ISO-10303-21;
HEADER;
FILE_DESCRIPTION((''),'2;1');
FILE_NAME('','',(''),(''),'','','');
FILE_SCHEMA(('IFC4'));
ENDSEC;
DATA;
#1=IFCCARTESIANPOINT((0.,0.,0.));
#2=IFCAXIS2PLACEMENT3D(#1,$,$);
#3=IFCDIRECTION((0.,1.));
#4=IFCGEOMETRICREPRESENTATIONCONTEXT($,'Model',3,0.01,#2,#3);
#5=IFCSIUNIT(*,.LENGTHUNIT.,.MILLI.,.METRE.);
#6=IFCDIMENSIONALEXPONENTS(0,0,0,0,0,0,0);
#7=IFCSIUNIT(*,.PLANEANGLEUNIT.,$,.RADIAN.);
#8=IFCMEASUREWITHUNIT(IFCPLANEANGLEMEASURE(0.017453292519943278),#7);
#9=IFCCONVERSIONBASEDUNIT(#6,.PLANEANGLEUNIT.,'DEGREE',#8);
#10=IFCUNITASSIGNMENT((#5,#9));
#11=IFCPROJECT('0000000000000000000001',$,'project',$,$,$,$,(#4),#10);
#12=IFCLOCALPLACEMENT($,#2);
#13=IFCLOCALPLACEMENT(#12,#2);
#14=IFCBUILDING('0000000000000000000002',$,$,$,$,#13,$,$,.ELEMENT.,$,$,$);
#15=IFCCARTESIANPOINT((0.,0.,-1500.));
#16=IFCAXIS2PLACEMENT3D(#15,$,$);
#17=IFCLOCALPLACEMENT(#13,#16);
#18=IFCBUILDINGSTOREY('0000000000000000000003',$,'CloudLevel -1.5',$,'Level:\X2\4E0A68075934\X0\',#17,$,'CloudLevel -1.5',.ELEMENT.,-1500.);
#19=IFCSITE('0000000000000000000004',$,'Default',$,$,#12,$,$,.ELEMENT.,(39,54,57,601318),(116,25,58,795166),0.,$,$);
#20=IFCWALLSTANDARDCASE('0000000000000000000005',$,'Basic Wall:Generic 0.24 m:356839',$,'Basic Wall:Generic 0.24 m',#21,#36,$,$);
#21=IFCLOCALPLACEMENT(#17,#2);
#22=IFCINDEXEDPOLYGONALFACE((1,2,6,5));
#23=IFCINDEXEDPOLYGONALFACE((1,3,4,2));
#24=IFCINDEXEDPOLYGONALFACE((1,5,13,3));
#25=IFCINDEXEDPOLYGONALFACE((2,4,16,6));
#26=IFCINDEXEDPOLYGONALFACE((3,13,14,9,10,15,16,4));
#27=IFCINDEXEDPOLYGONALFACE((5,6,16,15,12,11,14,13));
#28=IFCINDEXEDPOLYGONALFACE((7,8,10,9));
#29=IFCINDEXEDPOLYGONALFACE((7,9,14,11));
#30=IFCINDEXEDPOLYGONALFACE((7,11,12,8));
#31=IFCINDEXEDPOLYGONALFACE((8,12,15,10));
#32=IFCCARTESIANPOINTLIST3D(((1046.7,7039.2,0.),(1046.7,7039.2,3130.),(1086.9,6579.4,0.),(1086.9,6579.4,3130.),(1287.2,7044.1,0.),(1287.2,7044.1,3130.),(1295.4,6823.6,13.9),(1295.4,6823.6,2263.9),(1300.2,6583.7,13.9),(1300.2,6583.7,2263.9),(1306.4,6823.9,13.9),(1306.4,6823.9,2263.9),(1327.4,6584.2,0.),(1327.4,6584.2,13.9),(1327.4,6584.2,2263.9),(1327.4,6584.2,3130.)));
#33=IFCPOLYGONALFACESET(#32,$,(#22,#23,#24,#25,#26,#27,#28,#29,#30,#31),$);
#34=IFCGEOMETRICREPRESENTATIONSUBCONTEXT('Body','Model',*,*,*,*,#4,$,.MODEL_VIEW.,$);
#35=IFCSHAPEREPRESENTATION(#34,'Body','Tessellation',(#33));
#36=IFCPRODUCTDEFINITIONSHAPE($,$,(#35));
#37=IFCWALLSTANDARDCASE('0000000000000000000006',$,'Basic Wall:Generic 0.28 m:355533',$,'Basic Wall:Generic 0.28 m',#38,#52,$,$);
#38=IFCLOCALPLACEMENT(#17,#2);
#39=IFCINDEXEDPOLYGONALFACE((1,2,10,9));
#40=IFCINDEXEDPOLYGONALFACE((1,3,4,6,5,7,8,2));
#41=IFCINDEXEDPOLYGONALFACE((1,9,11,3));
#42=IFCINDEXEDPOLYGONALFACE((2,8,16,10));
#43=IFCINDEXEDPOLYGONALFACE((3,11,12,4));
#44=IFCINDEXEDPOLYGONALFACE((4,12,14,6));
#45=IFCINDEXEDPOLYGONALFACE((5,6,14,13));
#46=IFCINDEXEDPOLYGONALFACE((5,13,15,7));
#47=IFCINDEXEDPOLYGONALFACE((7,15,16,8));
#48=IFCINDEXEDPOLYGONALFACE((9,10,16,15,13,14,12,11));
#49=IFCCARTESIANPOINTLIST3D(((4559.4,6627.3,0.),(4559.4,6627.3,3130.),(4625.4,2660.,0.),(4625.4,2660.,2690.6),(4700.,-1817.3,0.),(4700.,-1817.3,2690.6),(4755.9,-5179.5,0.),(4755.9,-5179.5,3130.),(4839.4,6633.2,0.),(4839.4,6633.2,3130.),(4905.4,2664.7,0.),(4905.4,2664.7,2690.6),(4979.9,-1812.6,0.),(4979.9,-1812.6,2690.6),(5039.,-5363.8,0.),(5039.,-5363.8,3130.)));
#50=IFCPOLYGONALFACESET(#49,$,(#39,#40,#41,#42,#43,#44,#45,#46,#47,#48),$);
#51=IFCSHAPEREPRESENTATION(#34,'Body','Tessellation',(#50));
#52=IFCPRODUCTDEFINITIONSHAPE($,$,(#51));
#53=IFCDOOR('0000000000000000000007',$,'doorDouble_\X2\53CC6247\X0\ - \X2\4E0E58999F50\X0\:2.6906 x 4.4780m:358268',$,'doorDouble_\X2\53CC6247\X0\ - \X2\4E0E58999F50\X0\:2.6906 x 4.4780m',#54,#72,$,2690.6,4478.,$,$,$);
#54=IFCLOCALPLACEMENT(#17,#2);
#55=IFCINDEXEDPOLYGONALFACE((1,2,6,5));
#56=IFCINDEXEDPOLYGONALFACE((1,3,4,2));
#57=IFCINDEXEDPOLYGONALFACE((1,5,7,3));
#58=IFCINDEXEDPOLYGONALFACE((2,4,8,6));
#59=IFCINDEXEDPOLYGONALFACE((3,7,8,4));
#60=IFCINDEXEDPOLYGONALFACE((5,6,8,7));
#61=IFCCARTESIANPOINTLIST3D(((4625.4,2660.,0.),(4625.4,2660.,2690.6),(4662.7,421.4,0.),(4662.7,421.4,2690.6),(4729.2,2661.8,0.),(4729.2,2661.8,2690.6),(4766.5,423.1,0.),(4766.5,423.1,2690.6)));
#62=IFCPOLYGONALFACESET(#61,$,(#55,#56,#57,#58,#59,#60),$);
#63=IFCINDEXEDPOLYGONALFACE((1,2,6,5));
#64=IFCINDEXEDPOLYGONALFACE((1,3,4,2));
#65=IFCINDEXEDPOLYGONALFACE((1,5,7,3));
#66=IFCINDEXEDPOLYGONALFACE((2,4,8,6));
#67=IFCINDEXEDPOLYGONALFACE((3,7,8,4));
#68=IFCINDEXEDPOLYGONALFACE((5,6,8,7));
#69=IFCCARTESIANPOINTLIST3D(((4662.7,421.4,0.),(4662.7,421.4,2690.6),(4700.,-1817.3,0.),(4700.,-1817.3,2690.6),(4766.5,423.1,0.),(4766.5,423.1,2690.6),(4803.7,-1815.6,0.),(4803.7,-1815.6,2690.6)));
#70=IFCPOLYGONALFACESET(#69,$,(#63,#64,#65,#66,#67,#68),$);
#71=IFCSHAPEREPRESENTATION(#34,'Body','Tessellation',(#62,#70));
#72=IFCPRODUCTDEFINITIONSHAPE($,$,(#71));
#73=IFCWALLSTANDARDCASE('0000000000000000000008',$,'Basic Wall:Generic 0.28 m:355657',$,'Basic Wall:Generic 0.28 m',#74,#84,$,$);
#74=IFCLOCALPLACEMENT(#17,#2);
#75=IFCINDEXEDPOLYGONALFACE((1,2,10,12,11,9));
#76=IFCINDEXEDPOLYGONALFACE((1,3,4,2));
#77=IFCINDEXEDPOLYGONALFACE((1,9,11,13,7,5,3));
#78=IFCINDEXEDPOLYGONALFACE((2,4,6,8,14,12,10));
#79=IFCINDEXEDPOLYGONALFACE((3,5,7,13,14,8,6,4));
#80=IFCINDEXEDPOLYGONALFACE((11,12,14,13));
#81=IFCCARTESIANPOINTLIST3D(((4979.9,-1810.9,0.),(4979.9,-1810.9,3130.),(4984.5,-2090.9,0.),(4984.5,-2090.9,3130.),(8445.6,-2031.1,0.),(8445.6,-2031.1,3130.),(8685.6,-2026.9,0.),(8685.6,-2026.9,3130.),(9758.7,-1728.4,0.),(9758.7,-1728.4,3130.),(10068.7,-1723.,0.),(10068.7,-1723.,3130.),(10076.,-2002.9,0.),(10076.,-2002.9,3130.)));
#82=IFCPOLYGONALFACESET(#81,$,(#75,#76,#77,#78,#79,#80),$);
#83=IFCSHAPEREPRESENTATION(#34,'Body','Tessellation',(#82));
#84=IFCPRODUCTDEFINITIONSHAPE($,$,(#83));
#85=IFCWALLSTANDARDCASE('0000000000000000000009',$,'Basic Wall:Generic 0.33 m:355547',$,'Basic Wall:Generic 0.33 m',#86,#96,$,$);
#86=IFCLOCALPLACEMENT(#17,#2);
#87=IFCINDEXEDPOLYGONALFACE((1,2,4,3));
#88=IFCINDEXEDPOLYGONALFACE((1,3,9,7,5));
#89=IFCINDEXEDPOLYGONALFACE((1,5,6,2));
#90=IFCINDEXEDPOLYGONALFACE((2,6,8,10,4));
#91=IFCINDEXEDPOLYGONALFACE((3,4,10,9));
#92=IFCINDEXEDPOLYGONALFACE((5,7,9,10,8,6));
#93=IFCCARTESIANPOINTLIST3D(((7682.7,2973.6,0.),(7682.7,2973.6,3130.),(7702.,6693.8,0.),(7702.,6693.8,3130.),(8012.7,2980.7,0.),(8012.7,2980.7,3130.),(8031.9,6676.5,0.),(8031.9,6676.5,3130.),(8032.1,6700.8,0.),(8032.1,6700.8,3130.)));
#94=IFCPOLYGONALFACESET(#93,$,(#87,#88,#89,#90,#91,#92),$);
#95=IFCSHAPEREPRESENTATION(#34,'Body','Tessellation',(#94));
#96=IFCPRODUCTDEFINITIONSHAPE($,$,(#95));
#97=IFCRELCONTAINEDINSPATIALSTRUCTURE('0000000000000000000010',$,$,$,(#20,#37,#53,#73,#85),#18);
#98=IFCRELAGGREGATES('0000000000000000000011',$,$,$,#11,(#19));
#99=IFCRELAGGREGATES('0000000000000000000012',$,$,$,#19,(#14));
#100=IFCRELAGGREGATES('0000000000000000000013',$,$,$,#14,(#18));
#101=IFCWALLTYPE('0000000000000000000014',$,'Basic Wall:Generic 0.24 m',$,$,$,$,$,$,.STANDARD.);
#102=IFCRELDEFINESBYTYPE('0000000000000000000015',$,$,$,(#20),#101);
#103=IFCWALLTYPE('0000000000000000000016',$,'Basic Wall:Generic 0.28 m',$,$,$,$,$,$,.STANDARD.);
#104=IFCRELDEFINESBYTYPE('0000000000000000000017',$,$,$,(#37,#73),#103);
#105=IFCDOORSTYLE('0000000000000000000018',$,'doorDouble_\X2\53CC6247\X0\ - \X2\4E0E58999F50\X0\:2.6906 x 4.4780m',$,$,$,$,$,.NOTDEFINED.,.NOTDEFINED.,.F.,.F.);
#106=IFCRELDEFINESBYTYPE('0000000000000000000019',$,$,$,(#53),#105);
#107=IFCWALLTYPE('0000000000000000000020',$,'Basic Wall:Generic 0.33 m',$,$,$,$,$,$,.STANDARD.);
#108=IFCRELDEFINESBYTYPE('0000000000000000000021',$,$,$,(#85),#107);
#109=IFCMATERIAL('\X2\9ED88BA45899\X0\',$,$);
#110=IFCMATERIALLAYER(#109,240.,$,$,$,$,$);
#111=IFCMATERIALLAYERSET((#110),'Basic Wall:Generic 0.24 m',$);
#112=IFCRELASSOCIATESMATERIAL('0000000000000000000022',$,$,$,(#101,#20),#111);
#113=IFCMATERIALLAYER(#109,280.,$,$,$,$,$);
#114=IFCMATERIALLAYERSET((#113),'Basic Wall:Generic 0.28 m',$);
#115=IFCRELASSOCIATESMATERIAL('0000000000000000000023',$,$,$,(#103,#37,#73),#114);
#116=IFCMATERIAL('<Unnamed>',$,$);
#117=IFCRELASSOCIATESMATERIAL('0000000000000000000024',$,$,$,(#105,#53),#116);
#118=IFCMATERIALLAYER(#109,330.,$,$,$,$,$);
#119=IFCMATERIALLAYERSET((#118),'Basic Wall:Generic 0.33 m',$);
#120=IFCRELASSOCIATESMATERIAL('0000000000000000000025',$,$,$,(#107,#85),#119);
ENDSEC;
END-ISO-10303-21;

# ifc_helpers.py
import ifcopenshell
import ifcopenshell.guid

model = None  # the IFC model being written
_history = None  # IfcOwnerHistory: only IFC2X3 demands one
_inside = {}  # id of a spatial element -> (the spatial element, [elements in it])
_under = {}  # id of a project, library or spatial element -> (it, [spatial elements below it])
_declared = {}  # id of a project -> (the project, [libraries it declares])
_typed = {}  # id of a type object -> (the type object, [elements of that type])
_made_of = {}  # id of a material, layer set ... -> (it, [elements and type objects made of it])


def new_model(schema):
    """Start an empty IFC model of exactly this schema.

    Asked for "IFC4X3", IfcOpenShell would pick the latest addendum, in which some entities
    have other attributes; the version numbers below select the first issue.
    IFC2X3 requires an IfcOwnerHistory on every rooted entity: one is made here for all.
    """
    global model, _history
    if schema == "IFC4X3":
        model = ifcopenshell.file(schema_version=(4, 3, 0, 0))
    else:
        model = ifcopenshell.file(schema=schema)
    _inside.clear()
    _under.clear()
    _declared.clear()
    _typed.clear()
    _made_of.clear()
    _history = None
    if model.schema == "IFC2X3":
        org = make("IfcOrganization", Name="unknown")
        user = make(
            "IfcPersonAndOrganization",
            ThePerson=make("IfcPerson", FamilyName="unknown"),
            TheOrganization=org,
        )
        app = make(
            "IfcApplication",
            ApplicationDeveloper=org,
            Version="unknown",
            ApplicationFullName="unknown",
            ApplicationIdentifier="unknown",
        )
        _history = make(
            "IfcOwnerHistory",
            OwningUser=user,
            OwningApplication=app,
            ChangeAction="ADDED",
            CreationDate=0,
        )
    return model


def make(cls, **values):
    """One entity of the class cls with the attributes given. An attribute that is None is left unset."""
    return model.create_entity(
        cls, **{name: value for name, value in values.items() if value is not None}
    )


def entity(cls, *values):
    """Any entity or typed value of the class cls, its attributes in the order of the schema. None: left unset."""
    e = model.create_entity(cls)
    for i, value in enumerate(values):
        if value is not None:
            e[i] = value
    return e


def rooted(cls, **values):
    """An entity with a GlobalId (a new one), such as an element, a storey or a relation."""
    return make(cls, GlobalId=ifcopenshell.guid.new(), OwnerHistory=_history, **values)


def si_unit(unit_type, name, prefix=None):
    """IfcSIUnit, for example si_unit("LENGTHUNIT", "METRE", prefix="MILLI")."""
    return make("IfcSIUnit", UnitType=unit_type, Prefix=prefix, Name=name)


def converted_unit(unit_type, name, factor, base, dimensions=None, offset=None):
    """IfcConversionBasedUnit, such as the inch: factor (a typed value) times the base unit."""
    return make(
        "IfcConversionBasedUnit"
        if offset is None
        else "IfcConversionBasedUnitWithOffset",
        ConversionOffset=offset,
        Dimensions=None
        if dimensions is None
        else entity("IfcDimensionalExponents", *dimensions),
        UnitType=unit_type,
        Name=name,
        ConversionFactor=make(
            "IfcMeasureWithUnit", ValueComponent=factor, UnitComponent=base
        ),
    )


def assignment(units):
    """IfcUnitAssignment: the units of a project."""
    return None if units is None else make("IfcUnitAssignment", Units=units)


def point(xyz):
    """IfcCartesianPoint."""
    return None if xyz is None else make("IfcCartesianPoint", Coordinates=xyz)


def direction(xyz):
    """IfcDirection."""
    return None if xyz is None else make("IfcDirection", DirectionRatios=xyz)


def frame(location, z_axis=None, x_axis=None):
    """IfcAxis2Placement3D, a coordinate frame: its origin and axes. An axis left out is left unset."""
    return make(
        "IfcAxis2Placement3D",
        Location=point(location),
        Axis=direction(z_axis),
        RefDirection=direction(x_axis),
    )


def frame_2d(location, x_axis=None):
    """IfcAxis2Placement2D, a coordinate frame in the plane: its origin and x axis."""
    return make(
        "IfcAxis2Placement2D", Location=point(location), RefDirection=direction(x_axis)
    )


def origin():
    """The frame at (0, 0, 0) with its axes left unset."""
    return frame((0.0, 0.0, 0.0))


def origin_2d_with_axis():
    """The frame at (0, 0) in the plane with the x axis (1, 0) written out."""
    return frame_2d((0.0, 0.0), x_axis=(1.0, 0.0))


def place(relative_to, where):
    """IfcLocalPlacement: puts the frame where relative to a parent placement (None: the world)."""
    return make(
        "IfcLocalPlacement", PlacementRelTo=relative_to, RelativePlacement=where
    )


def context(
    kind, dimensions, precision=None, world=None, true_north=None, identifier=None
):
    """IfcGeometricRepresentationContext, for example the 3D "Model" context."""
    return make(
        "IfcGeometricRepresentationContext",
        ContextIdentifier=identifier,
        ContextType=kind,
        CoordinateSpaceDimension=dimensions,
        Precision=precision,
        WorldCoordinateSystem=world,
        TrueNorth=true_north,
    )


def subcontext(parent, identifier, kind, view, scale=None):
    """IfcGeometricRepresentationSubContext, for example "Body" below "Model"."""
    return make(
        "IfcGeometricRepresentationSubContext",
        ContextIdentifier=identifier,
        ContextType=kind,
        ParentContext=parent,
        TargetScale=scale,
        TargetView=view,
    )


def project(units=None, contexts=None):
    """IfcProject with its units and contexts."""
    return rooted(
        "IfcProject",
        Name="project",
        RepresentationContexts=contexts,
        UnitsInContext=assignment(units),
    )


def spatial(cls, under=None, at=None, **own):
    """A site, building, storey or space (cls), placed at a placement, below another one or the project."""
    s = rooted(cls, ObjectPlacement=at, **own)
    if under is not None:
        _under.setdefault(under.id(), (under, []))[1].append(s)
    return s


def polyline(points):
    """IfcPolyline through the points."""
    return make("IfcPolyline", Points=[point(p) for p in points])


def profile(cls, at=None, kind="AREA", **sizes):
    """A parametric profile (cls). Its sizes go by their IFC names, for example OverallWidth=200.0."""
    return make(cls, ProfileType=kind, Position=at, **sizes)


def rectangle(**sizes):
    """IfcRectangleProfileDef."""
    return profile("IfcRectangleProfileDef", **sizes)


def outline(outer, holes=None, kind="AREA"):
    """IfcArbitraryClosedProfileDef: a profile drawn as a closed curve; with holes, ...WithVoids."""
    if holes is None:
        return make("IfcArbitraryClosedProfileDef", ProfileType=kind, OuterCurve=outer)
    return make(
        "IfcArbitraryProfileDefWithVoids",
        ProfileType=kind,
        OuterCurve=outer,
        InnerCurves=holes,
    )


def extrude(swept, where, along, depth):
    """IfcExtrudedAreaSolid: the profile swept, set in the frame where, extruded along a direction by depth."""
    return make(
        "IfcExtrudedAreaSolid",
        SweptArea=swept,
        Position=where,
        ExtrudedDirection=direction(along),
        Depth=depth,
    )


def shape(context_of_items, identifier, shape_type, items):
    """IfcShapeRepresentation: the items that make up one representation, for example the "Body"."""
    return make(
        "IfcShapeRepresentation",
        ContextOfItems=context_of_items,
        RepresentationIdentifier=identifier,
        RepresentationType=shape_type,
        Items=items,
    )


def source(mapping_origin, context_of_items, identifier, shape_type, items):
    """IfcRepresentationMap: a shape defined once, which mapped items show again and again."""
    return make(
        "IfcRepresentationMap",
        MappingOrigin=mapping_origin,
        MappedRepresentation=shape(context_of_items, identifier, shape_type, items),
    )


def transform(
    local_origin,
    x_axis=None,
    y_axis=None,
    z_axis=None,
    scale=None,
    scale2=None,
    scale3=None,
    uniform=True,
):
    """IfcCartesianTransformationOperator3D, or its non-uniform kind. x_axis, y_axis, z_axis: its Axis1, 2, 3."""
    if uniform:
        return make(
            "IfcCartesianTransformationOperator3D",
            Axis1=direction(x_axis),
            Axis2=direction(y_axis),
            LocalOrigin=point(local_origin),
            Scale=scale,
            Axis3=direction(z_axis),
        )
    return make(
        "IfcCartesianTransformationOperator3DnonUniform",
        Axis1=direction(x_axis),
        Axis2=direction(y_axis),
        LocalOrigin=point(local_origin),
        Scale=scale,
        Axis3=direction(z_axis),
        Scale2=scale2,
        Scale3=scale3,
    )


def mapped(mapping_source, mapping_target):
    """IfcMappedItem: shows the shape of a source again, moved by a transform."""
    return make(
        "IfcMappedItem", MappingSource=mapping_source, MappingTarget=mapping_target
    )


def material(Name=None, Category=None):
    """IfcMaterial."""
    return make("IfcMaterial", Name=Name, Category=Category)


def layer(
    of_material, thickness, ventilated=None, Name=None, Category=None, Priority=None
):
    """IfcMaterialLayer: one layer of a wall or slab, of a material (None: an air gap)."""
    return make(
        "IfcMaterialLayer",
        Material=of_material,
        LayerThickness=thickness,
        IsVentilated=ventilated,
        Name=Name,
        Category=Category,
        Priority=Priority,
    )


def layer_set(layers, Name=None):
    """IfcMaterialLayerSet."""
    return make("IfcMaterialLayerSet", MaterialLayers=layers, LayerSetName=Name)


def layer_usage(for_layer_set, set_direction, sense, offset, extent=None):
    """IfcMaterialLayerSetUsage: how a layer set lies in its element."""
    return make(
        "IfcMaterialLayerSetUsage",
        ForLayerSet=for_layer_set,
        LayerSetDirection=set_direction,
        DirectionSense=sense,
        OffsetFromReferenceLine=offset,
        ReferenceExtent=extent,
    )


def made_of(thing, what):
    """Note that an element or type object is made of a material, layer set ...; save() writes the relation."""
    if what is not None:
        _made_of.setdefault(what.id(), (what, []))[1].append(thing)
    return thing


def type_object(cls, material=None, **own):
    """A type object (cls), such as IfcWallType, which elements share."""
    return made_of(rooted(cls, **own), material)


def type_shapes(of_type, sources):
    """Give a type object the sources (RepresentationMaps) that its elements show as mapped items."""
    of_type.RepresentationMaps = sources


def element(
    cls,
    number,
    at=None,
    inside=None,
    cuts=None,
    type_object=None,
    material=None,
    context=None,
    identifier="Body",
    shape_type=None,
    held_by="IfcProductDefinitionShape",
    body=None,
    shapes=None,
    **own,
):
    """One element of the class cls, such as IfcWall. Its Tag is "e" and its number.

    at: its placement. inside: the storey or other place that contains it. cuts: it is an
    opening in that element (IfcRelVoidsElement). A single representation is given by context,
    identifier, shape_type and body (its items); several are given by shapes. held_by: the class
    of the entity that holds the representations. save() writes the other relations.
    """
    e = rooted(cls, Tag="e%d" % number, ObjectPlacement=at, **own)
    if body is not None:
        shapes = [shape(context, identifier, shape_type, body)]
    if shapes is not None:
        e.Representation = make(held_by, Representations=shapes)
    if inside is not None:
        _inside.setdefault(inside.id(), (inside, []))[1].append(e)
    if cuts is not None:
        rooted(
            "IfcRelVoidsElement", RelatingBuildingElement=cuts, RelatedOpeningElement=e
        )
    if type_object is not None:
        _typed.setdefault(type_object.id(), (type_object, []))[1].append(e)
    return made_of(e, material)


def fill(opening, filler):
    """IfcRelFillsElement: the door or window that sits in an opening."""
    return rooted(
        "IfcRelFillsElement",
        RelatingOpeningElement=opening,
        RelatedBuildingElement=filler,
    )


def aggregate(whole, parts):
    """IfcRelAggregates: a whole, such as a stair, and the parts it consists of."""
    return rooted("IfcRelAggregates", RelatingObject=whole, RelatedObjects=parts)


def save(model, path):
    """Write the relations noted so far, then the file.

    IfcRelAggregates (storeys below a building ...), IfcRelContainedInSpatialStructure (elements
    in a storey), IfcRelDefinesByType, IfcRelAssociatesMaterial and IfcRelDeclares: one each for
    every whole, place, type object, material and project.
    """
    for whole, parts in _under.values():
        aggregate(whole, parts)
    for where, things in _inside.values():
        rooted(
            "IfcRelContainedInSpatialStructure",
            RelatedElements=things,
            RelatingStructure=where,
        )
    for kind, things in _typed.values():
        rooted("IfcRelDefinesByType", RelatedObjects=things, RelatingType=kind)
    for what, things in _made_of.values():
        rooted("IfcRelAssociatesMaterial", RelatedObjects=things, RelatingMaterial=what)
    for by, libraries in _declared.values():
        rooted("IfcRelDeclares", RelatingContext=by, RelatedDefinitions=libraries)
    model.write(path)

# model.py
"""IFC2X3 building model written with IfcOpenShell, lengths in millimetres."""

from ifc_helpers import new_model, entity, si_unit, converted_unit, direction, frame, frame_2d, origin, origin_2d_with_axis, place, context, subcontext, project, spatial, polyline, rectangle, outline, extrude, source, transform, mapped, material, layer, layer_set, layer_usage, type_object, type_shapes, element, fill, save


model = new_model("IFC2X3")

# Units and contexts
model_context = context("Model", 3, precision=0.01, world=origin(), true_north=direction((0.0, 1.0)))
body_context = subcontext(model_context, "Body", "Model", "MODEL_VIEW")
ifc_project = project(units=[si_unit("LENGTHUNIT", "METRE", prefix="MILLI"), converted_unit("PLANEANGLEUNIT", "DEGREE", entity("IfcPlaneAngleMeasure", 0.017453292519943278), si_unit("PLANEANGLEUNIT", "RADIAN"), dimensions=[0, 0, 0, 0, 0, 0, 0])], contexts=[model_context])

# Site, building, storey
site_placement = place(None, origin())
site = spatial("IfcSite", under=ifc_project, at=site_placement, Name="Default", CompositionType="ELEMENT", RefLatitude=(39, 54, 57, 601318), RefLongitude=(116, 25, 58, 795166), RefElevation=0.0)
building_placement = place(site_placement, origin())
building = spatial("IfcBuilding", under=site, at=building_placement, CompositionType="ELEMENT")
storey_placement = place(building_placement, frame((0.0, 0.0, -1500.0)))
storey = spatial("IfcBuildingStorey", under=building, at=storey_placement, Name="CloudLevel -1.5", ObjectType="Level:上标头", LongName="CloudLevel -1.5", CompositionType="ELEMENT", Elevation=-1500.0)

# Shared definitions
ifc_material_1 = material(Name="默认墙")
ifc_layer_1 = layer(ifc_material_1, 240.0)
ifc_layer_set_1 = layer_set([ifc_layer_1], Name="Basic Wall:Generic 0.24 m")
ifc_layer_usage_1 = layer_usage(ifc_layer_set_1, "AXIS2", "NEGATIVE", 120.0)
wall_type_1 = type_object("IfcWallType", Name="Basic Wall:Generic 0.24 m", PredefinedType="STANDARD", material=ifc_layer_set_1)

# Wall, opening
wall_1_placement = place(storey_placement, frame((1207.8, 6573.8, 0.0), z_axis=(0.0, 0.0, 1.0), x_axis=(-0.087156, 0.996195, 0.0)))
wall_1 = element("IfcWallStandardCase", 1, at=wall_1_placement, inside=storey, type_object=wall_type_1, material=ifc_layer_usage_1, Name="Basic Wall:Generic 0.24 m:356839", ObjectType="Basic Wall:Generic 0.24 m", context=body_context, shape_type="SweptSolid", body=[
    extrude(outline(polyline([(461.6, -120.0), (477.7, 120.0), (237.2, 120.0), (16.2, 120.0), (0.0, -120.0), (240.5, -120.0), (461.6, -120.0)])), origin(), (0.0, 0.0, 1.0), 3130.0),
])
opening_1_placement = place(wall_1_placement, origin())
element("IfcOpeningElement", 2, at=opening_1_placement, cuts=wall_1, ObjectType="Opening", context=body_context, shape_type="SweptSolid", body=[
    extrude(rectangle(XDim=2250.0, YDim=240.0, at=frame_2d((0.0, 0.0), x_axis=(0.0, 1.0))), frame((56.3, -1068.7, 1138.9), z_axis=(0.067256, 0.997736, 0.0), x_axis=(-0.997736, 0.067256, 0.0)), (0.0, 0.0, 1.0), 970.0),
])

# Wall, opening, door
ifc_layer_2 = layer(ifc_material_1, 280.0)
ifc_layer_set_2 = layer_set([ifc_layer_2], Name="Basic Wall:Generic 0.28 m")
ifc_layer_usage_2 = layer_usage(ifc_layer_set_2, "AXIS2", "NEGATIVE", 140.0)
wall_type_2 = type_object("IfcWallType", Name="Basic Wall:Generic 0.28 m", PredefinedType="STANDARD", material=ifc_layer_set_2)
wall_2_placement = place(storey_placement, frame((4699.4, 6630.9, 0.0), z_axis=(0.0, 0.0, 1.0), x_axis=(0.016639, -0.999862, 0.0)))
wall_2 = element("IfcWallStandardCase", 3, at=wall_2_placement, inside=storey, type_object=wall_type_2, material=ifc_layer_usage_2, Name="Basic Wall:Generic 0.28 m:355533", ObjectType="Basic Wall:Generic 0.28 m", context=body_context, shape_type="SweptSolid", body=[
    extrude(outline(polyline([(1.3, -140.0), (2220.4, -140.0), (2470.4, -140.0), (11022.1, -140.0), (11672.1, -140.0), (11809.7, -140.0), (11998.7, 140.0), (8725.3, 140.0), (8445.3, 140.0), (3989.7, 140.0), (3719.7, 140.0), (0.0, 140.0), (1.3, -140.0)])), origin(), (0.0, 0.0, 1.0), 3130.0),
])
opening_2_placement = place(wall_2_placement, frame((3969.1, -140.0, 0.0)))
opening_2 = element("IfcOpeningElement", 4, at=opening_2_placement, cuts=wall_2, ObjectType="Opening", context=body_context, shape_type="SweptSolid", body=[
    extrude(rectangle(XDim=2690.6, YDim=4478.0, at=frame_2d((1345.3, 2239.0), x_axis=(1.0, 0.0))), frame((0.0, 0.0, 0.0), z_axis=(0.0, 1.0, 0.0), x_axis=(0.0, 0.0, 1.0)), (0.0, 0.0, 1.0), 280.0),
])
ifc_material_2 = material(Name="<Unnamed>")
door_style_1 = type_object("IfcDoorStyle", Name="doorDouble_双扇 - 与墙齐:2.6906 x 4.4780m", ConstructionType="NOTDEFINED", OperationType="NOTDEFINED", ParameterTakesPrecedence=False, Sizeable=False, material=ifc_material_2)
shared_shape_1 = source(origin(), body_context, "Body", "SweptSolid", [
    extrude(rectangle(XDim=2239.0, YDim=103.8, at=origin_2d_with_axis()), frame((3358.5, 228.1, 0.0), z_axis=(0.0, 0.0, 1.0), x_axis=(-1.0, 0.0, 0.0)), (0.0, 0.0, 1.0), 2690.6),
    extrude(rectangle(XDim=2239.0, YDim=103.8, at=origin_2d_with_axis()), frame((1119.5, 228.1, 0.0), z_axis=(0.0, 0.0, 1.0), x_axis=(-1.0, 0.0, 0.0)), (0.0, 0.0, 1.0), 2690.6),
])
type_shapes(door_style_1, [shared_shape_1])
door_1_placement = place(opening_2_placement, frame((4478.0, 280.0, 0.0), z_axis=(0.0, 0.0, 1.0), x_axis=(-1.0, 0.0, 0.0)))
door_1 = element("IfcDoor", 5, at=door_1_placement, inside=storey, type_object=door_style_1, material=ifc_material_2, Name="doorDouble_双扇 - 与墙齐:2.6906 x 4.4780m:358268", ObjectType="doorDouble_双扇 - 与墙齐:2.6906 x 4.4780m", OverallHeight=2690.6, OverallWidth=4478.0, context=body_context, shape_type="MappedRepresentation", body=[
    mapped(shared_shape_1, transform((0.0, 0.0, 0.0), scale=1.0)),
])
fill(opening_2, door_1)

# Walls
wall_3_placement = place(storey_placement, frame((4982.1, -1950.9, 0.0), z_axis=(0.0, 0.0, 1.0), x_axis=(0.999851, 0.017275, 0.0)))
element("IfcWallStandardCase", 6, at=wall_3_placement, inside=storey, type_object=wall_type_2, material=ifc_layer_usage_2, Name="Basic Wall:Generic 0.28 m:355657", ObjectType="Basic Wall:Generic 0.28 m", context=body_context, shape_type="SweptSolid", body=[
    extrude(outline(polyline([(5092.2, -140.0), (5089.7, 140.0), (4779.7, 140.0), (0.2, 140.0), (0.0, -140.0), (3461.6, -140.0), (3701.6, -140.0), (5092.2, -140.0)])), origin(), (0.0, 0.0, 1.0), 3130.0),
])
ifc_layer_3 = layer(ifc_material_1, 330.0)
ifc_layer_set_3 = layer_set([ifc_layer_3], Name="Basic Wall:Generic 0.33 m")
ifc_layer_usage_3 = layer_usage(ifc_layer_set_3, "AXIS2", "NEGATIVE", 165.0)
wall_type_3 = type_object("IfcWallType", Name="Basic Wall:Generic 0.33 m", PredefinedType="STANDARD", material=ifc_layer_set_3)
wall_4_placement = place(storey_placement, frame((7847.7, 2972.8, 0.0), z_axis=(0.0, 0.0, 1.0), x_axis=(0.005205, 0.999986, 0.0)))
element("IfcWallStandardCase", 7, at=wall_4_placement, inside=storey, type_object=wall_type_3, material=ifc_layer_usage_3, Name="Basic Wall:Generic 0.33 m:355547", ObjectType="Basic Wall:Generic 0.33 m", context=body_context, shape_type="SweptSolid", body=[
    extrude(outline(polyline([(3729.0, -165.0), (3720.3, 165.0), (0.0, 165.0), (8.8, -165.0), (3704.6, -165.0), (3729.0, -165.0)])), origin(), (0.0, 0.0, 1.0), 3130.0),
])

save(model, "model.ifc")
